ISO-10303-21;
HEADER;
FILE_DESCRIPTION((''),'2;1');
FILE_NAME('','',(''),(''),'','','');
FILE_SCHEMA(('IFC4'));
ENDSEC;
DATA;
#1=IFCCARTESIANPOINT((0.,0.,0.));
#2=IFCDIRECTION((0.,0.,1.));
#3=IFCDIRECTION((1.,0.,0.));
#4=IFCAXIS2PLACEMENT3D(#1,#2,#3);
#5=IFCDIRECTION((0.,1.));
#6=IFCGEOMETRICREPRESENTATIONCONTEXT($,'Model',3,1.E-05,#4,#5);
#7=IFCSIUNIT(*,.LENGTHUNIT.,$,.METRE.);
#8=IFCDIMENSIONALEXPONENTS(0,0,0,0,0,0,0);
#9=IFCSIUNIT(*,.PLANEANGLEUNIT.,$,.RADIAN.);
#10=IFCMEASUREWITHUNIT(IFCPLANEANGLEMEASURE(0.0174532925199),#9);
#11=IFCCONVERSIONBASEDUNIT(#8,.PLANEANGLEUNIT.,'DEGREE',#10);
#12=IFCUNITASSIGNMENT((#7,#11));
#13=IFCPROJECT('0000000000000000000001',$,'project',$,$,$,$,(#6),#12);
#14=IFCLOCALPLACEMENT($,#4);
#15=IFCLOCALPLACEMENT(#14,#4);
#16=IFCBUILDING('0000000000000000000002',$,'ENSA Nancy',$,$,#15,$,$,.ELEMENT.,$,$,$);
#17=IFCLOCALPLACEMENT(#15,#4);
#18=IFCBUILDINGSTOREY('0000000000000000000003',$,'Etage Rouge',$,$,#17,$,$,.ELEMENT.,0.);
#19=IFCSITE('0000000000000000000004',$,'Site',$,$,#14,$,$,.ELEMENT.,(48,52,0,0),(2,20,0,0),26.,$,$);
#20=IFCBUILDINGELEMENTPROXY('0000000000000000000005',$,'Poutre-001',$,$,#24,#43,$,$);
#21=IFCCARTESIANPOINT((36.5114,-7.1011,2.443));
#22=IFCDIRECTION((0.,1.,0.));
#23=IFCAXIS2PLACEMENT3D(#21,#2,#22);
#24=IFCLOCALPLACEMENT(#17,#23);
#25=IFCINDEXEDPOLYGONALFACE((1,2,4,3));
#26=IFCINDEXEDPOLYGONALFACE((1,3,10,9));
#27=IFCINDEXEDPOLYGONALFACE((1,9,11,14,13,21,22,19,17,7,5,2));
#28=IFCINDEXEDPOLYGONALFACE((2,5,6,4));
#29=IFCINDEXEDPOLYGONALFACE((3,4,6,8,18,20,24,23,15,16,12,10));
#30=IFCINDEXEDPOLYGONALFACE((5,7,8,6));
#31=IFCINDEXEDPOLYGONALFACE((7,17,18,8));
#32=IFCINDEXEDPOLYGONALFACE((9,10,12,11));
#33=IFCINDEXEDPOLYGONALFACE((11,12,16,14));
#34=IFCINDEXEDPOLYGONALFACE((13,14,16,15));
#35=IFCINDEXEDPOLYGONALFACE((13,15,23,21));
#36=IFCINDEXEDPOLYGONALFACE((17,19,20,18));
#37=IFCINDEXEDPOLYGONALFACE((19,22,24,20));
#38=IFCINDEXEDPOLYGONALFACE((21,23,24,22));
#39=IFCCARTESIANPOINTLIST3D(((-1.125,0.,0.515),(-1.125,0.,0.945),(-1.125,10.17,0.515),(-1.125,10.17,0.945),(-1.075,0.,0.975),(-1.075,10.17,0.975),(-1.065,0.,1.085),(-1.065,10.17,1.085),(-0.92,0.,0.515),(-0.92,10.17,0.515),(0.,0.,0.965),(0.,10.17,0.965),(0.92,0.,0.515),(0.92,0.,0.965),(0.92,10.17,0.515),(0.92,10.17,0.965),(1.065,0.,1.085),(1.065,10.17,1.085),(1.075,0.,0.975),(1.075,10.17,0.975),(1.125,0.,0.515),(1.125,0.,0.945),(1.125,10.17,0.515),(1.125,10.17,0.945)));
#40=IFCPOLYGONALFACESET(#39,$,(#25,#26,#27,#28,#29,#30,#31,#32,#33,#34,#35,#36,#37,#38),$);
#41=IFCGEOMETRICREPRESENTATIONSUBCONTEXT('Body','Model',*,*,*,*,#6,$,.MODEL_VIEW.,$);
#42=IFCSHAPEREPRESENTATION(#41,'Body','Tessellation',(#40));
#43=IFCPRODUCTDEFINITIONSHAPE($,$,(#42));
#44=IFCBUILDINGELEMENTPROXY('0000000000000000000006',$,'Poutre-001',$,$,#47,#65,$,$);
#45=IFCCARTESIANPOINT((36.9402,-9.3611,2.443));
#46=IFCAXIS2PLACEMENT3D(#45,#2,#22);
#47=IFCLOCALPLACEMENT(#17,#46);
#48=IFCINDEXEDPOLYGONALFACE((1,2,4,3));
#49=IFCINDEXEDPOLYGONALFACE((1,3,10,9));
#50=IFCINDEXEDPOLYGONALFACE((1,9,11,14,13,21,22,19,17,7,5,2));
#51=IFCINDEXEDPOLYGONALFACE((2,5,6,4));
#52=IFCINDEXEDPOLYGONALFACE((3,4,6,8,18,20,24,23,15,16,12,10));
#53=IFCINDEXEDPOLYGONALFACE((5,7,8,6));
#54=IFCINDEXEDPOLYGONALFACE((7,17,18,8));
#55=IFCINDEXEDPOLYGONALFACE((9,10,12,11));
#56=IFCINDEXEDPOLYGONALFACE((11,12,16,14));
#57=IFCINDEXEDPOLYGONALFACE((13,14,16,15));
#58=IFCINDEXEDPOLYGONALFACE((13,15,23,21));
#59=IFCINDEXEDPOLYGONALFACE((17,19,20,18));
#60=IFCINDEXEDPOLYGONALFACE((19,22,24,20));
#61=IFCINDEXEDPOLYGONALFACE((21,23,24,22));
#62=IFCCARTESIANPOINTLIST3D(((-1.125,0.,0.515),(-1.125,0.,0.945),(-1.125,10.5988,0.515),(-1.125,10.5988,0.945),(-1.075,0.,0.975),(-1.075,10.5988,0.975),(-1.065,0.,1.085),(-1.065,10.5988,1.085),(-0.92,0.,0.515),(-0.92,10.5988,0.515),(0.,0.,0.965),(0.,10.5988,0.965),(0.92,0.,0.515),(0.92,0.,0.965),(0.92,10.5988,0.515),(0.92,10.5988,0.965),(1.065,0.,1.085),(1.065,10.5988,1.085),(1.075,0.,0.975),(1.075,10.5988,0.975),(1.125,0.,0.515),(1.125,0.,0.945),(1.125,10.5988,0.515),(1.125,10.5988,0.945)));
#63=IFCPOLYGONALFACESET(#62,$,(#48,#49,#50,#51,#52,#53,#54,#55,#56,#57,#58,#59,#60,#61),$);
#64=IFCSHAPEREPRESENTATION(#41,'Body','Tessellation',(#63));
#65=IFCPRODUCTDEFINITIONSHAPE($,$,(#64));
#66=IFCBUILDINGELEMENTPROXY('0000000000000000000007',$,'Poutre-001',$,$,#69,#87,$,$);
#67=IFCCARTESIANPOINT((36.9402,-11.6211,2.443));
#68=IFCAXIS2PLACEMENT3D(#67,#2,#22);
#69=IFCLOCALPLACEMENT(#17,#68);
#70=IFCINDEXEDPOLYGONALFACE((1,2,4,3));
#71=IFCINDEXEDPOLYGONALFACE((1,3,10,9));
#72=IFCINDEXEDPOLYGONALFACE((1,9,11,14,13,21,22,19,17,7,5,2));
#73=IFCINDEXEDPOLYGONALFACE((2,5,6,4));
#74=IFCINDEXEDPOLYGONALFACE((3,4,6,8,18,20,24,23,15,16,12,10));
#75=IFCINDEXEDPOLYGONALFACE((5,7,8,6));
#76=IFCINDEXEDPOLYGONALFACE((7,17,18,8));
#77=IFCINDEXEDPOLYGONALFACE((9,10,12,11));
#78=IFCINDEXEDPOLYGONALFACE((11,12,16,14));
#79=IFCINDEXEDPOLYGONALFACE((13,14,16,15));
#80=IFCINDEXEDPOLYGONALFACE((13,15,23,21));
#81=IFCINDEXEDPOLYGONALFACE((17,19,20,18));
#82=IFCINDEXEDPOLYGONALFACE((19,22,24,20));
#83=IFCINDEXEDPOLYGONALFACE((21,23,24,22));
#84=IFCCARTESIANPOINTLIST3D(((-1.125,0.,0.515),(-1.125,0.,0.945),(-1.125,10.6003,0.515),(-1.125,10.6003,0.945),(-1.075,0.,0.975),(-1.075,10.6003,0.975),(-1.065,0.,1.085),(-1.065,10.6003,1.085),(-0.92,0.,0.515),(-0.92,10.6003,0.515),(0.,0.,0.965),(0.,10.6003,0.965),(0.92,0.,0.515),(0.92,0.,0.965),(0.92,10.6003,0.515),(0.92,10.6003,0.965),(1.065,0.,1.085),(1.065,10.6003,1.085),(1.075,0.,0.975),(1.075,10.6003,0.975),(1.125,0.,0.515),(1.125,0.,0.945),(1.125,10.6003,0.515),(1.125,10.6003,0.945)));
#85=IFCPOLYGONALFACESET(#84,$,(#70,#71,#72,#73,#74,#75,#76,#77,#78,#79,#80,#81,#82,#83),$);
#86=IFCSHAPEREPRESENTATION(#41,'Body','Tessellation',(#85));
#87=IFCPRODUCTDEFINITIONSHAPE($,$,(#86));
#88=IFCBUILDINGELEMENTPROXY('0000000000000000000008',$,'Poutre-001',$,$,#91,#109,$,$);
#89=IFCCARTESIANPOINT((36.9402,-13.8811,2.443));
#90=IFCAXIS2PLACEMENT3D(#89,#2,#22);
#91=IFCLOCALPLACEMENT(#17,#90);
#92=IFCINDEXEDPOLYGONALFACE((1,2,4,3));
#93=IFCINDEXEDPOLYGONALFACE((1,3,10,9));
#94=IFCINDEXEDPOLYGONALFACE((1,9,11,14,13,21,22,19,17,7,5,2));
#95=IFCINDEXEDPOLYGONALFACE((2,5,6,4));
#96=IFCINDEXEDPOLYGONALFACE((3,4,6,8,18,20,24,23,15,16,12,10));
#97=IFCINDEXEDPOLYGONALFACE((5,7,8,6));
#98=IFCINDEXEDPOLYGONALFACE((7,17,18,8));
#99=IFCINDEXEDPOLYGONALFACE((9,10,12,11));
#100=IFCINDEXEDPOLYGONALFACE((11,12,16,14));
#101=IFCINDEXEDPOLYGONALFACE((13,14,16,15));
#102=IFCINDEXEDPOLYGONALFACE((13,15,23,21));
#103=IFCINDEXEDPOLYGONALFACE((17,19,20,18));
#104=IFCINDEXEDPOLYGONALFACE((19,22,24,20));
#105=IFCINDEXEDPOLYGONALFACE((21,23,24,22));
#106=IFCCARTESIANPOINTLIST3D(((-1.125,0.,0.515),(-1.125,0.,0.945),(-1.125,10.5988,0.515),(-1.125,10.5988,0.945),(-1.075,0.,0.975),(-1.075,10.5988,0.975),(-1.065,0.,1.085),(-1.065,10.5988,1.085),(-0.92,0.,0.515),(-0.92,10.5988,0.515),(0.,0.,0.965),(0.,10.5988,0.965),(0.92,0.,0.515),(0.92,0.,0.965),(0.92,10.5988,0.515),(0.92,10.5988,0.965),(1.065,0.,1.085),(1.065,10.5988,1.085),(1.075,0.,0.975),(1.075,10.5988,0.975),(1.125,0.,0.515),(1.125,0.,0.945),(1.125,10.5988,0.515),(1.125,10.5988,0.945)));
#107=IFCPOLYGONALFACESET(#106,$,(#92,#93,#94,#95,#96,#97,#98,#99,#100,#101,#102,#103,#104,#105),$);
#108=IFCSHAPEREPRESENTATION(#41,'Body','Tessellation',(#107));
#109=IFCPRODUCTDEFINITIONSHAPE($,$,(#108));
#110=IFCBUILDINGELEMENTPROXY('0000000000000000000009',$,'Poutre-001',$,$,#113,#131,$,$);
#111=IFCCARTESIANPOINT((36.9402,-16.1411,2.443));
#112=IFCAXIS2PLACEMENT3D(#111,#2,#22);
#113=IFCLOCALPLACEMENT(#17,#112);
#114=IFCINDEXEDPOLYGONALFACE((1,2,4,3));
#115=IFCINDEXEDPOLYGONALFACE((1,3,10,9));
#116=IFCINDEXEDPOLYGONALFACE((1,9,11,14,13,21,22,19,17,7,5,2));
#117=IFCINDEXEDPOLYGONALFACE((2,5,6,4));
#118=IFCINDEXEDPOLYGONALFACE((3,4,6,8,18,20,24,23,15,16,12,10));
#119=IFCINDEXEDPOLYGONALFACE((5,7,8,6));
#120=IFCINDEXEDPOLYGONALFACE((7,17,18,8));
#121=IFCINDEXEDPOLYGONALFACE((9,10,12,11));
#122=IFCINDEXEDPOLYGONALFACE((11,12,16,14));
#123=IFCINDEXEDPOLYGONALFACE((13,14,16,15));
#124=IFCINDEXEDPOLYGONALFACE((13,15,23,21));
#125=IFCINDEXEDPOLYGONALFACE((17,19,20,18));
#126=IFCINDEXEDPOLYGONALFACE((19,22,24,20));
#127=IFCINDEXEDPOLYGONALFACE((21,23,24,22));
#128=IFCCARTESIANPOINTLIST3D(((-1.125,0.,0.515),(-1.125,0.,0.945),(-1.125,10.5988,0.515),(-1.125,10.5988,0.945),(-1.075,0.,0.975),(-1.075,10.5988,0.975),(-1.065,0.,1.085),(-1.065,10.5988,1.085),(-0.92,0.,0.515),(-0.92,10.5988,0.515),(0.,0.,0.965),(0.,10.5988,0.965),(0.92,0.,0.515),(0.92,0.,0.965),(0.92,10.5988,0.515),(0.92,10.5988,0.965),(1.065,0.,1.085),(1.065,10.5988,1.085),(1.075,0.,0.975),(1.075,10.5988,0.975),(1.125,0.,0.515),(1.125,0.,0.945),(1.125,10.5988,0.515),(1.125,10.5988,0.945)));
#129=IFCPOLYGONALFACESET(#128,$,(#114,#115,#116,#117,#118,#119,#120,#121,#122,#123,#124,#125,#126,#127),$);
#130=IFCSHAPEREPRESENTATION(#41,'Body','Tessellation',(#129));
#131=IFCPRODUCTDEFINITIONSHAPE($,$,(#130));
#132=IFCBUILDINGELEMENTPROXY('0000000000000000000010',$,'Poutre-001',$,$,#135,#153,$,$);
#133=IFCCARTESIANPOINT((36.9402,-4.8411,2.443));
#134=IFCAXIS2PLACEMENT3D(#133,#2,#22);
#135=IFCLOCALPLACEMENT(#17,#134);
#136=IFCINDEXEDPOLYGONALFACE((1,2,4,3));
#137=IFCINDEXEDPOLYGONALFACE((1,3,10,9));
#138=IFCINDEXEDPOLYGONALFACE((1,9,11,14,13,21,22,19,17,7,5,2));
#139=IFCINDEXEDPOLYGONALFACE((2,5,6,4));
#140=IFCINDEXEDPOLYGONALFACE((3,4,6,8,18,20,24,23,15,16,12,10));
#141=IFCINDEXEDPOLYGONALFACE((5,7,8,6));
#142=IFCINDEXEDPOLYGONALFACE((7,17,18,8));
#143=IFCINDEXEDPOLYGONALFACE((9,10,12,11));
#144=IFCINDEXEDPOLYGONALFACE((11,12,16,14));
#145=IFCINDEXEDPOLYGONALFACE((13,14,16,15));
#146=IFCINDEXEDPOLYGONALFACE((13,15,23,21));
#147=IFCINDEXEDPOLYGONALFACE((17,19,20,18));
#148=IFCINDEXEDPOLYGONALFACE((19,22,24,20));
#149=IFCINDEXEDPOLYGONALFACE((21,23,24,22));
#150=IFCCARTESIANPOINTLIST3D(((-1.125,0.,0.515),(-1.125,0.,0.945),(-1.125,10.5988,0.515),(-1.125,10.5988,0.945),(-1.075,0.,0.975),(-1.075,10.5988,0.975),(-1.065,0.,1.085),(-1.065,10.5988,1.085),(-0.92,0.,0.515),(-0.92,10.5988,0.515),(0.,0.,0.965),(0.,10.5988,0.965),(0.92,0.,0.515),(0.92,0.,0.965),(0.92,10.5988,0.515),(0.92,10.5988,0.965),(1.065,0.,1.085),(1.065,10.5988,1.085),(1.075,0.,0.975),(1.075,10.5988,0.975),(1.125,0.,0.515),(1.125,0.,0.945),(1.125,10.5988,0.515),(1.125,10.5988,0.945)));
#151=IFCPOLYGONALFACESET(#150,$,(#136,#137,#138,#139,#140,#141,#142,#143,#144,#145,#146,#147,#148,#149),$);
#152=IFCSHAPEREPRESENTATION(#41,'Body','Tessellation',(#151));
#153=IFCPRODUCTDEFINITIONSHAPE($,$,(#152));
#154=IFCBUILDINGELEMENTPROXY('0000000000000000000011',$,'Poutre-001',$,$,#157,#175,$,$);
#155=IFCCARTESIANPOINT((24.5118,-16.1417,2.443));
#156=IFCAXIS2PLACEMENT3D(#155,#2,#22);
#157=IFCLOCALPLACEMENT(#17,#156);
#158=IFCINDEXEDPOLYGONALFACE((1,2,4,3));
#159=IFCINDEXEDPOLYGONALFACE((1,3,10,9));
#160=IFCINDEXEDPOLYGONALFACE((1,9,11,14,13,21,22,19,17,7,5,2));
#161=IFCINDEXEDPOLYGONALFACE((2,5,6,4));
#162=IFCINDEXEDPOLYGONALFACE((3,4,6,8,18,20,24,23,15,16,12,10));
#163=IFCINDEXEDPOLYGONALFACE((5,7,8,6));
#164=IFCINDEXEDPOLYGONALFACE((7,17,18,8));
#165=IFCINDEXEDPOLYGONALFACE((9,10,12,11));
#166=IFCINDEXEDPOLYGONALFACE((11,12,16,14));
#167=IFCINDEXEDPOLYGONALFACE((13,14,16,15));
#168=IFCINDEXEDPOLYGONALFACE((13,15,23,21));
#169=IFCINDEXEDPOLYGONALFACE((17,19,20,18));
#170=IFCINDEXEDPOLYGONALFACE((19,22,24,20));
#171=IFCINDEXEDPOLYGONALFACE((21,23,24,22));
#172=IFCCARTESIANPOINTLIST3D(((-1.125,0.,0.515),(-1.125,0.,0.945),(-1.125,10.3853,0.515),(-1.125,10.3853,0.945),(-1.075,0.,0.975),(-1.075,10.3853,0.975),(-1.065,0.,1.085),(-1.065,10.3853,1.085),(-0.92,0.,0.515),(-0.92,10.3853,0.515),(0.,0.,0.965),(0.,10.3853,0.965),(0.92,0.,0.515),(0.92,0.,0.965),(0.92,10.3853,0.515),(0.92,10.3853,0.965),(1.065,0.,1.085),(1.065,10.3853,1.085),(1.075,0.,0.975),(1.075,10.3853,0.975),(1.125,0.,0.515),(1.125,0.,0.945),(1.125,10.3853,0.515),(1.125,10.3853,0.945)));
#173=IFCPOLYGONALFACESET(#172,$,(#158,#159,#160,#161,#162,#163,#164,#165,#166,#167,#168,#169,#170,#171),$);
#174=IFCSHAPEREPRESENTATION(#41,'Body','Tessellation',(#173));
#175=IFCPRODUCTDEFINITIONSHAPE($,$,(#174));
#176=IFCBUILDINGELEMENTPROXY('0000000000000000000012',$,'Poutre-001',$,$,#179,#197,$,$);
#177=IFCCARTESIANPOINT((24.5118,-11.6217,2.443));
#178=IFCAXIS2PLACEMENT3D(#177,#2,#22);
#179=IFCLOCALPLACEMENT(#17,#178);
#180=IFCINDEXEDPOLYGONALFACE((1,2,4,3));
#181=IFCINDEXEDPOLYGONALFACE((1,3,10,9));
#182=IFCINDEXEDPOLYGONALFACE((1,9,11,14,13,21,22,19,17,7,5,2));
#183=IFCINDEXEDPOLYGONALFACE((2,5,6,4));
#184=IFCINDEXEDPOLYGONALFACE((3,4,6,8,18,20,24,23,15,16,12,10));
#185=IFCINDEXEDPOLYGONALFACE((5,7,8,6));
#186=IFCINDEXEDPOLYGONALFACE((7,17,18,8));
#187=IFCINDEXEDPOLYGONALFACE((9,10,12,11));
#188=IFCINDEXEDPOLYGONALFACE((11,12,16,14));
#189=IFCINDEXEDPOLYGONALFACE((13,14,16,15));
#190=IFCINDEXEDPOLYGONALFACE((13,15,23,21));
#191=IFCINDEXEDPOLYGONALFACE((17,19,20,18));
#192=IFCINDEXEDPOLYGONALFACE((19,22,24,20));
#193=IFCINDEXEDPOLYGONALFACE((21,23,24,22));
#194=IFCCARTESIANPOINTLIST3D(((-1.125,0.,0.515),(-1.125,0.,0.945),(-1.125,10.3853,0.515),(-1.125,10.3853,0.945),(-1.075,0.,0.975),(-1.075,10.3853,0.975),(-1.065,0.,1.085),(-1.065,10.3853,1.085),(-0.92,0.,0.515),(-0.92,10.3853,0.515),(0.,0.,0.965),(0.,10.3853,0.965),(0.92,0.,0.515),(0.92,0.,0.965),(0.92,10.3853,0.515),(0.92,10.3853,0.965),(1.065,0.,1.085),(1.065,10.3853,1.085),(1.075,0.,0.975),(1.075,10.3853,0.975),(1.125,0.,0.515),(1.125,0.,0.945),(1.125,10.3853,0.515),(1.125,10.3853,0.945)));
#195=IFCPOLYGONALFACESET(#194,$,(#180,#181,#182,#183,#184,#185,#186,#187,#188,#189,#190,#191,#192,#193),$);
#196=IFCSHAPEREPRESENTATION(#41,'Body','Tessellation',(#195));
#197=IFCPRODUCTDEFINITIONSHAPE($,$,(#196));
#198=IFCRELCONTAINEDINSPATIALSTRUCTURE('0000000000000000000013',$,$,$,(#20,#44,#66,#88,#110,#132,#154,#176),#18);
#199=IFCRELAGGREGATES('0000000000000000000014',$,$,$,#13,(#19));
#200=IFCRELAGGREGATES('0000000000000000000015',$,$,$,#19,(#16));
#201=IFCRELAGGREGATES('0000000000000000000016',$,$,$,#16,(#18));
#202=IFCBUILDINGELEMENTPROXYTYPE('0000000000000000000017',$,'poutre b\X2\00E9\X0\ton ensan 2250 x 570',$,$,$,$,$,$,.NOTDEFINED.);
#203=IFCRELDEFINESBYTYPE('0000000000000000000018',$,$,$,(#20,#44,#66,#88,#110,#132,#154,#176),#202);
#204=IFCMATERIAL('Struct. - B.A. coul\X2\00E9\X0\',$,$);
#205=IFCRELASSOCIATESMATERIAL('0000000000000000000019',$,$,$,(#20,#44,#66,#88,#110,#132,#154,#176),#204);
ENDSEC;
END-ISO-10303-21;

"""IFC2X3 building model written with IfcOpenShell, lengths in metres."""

from ifc_helpers import new_model, entity, si_unit, converted_unit, direction, frame, origin_with_axes, place, context, subcontext, project, spatial, polyline, outline, extrude, material, type_object, element, save


model = new_model("IFC2X3")

# Units and contexts
model_context = context("Model", 3, precision=1e-05, world=origin_with_axes(), true_north=direction((0.0, 1.0)))
body_context = subcontext(model_context, "Body", "Model", "MODEL_VIEW")
ifc_project = project(units=[si_unit("LENGTHUNIT", "METRE"), converted_unit("PLANEANGLEUNIT", "DEGREE", entity("IfcPlaneAngleMeasure", 0.0174532925199), si_unit("PLANEANGLEUNIT", "RADIAN"), dimensions=[0, 0, 0, 0, 0, 0, 0])], contexts=[model_context])

# Site, building, storey
site_placement = place(None, origin_with_axes())
site = spatial("IfcSite", under=ifc_project, at=site_placement, Name="Site", CompositionType="ELEMENT", RefLatitude=(48, 52, 0, 0), RefLongitude=(2, 20, 0, 0), RefElevation=26.0)
building_placement = place(site_placement, origin_with_axes())
building = spatial("IfcBuilding", under=site, at=building_placement, Name="ENSA Nancy", CompositionType="ELEMENT")
storey_placement = place(building_placement, origin_with_axes())
storey = spatial("IfcBuildingStorey", under=building, at=storey_placement, Name="Etage Rouge", CompositionType="ELEMENT", Elevation=0.0)

# Building element proxies
ifc_material_1 = material(Name="Struct. - B.A. coulé")
building_element_proxy_type_1 = type_object("IfcBuildingElementProxyType", Name="poutre béton ensan 2250 x 570", PredefinedType="NOTDEFINED")
proxy_1_placement = place(storey_placement, frame((36.5114, -7.1011, 2.443), z_axis=(0.0, 0.0, 1.0), x_axis=(0.0, 1.0, 0.0)))
element("IfcBuildingElementProxy", 1, at=proxy_1_placement, inside=storey, type_object=building_element_proxy_type_1, material=ifc_material_1, Name="Poutre-001", context=body_context, shape_type="SweptSolid", body=[
    extrude(outline(polyline([(-1.065, 1.085), (-1.075, 0.975), (-1.125, 0.945), (-1.125, 0.515), (-0.92, 0.515), (0.0, 0.965), (0.92, 0.965), (0.92, 0.515), (1.125, 0.515), (1.125, 0.945), (1.075, 0.975), (1.065, 1.085), (-1.065, 1.085)])), frame((0.0, 10.17, 0.0), z_axis=(0.0, -1.0, 0.0), x_axis=(1.0, 0.0, 0.0)), (0.0, 0.0, 1.0), 10.17),
])
proxy_2_placement = place(storey_placement, frame((36.9402, -9.3611, 2.443), z_axis=(0.0, 0.0, 1.0), x_axis=(0.0, 1.0, 0.0)))
element("IfcBuildingElementProxy", 2, at=proxy_2_placement, inside=storey, type_object=building_element_proxy_type_1, material=ifc_material_1, Name="Poutre-001", context=body_context, shape_type="SweptSolid", body=[
    extrude(outline(polyline([(-1.065, 1.085), (-1.075, 0.975), (-1.125, 0.945), (-1.125, 0.515), (-0.92, 0.515), (0.0, 0.965), (0.92, 0.965), (0.92, 0.515), (1.125, 0.515), (1.125, 0.945), (1.075, 0.975), (1.065, 1.085), (-1.065, 1.085)])), frame((0.0, 10.5988, 0.0), z_axis=(0.0, -1.0, 0.0), x_axis=(1.0, 0.0, 0.0)), (0.0, 0.0, 1.0), 10.5988),
])
proxy_3_placement = place(storey_placement, frame((36.9402, -11.6211, 2.443), z_axis=(0.0, 0.0, 1.0), x_axis=(0.0, 1.0, 0.0)))
element("IfcBuildingElementProxy", 3, at=proxy_3_placement, inside=storey, type_object=building_element_proxy_type_1, material=ifc_material_1, Name="Poutre-001", context=body_context, shape_type="SweptSolid", body=[
    extrude(outline(polyline([(-1.065, 1.085), (-1.075, 0.975), (-1.125, 0.945), (-1.125, 0.515), (-0.92, 0.515), (0.0, 0.965), (0.92, 0.965), (0.92, 0.515), (1.125, 0.515), (1.125, 0.945), (1.075, 0.975), (1.065, 1.085), (-1.065, 1.085)])), frame((0.0, 10.6003, 0.0), z_axis=(0.0, -1.0, 0.0), x_axis=(1.0, 0.0, 0.0)), (0.0, 0.0, 1.0), 10.6003),
])
for number, where, z_axis, x_axis, name in (
    (4, (36.9402, -13.8811, 2.443), (0.0, 0.0, 1.0), (0.0, 1.0, 0.0), "Poutre-001"),
    (5, (36.9402, -16.1411, 2.443), (0.0, 0.0, 1.0), (0.0, 1.0, 0.0), "Poutre-001"),
    (6, (36.9402, -4.8411, 2.443), (0.0, 0.0, 1.0), (0.0, 1.0, 0.0), "Poutre-001"),
):
    element("IfcBuildingElementProxy", number, at=place(storey_placement, frame(where, z_axis=z_axis, x_axis=x_axis)), inside=storey, type_object=building_element_proxy_type_1, material=ifc_material_1, Name=name, context=body_context, shape_type="SweptSolid", body=[
        extrude(outline(polyline([(-1.065, 1.085), (-1.075, 0.975), (-1.125, 0.945), (-1.125, 0.515), (-0.92, 0.515), (0.0, 0.965), (0.92, 0.965), (0.92, 0.515), (1.125, 0.515), (1.125, 0.945), (1.075, 0.975), (1.065, 1.085), (-1.065, 1.085)])), frame((0.0, 10.5988, 0.0), z_axis=(0.0, -1.0, 0.0), x_axis=(1.0, 0.0, 0.0)), (0.0, 0.0, 1.0), 10.5988),
    ])
for number, where, z_axis, x_axis, name in (
    (7, (24.5118, -16.1417, 2.443), (0.0, 0.0, 1.0), (0.0, 1.0, 0.0), "Poutre-001"),
    (8, (24.5118, -11.6217, 2.443), (0.0, 0.0, 1.0), (0.0, 1.0, 0.0), "Poutre-001"),
):
    element("IfcBuildingElementProxy", number, at=place(storey_placement, frame(where, z_axis=z_axis, x_axis=x_axis)), inside=storey, type_object=building_element_proxy_type_1, material=ifc_material_1, Name=name, context=body_context, shape_type="SweptSolid", body=[
        extrude(outline(polyline([(-1.065, 1.085), (-1.075, 0.975), (-1.125, 0.945), (-1.125, 0.515), (-0.92, 0.515), (0.0, 0.965), (0.92, 0.965), (0.92, 0.515), (1.125, 0.515), (1.125, 0.945), (1.075, 0.975), (1.065, 1.085), (-1.065, 1.085)])), frame((0.0, 10.3853, 0.0), z_axis=(0.0, -1.0, 0.0), x_axis=(1.0, 0.0, 0.0)), (0.0, 0.0, 1.0), 10.3853),
    ])

save(model, "model.ifc")
